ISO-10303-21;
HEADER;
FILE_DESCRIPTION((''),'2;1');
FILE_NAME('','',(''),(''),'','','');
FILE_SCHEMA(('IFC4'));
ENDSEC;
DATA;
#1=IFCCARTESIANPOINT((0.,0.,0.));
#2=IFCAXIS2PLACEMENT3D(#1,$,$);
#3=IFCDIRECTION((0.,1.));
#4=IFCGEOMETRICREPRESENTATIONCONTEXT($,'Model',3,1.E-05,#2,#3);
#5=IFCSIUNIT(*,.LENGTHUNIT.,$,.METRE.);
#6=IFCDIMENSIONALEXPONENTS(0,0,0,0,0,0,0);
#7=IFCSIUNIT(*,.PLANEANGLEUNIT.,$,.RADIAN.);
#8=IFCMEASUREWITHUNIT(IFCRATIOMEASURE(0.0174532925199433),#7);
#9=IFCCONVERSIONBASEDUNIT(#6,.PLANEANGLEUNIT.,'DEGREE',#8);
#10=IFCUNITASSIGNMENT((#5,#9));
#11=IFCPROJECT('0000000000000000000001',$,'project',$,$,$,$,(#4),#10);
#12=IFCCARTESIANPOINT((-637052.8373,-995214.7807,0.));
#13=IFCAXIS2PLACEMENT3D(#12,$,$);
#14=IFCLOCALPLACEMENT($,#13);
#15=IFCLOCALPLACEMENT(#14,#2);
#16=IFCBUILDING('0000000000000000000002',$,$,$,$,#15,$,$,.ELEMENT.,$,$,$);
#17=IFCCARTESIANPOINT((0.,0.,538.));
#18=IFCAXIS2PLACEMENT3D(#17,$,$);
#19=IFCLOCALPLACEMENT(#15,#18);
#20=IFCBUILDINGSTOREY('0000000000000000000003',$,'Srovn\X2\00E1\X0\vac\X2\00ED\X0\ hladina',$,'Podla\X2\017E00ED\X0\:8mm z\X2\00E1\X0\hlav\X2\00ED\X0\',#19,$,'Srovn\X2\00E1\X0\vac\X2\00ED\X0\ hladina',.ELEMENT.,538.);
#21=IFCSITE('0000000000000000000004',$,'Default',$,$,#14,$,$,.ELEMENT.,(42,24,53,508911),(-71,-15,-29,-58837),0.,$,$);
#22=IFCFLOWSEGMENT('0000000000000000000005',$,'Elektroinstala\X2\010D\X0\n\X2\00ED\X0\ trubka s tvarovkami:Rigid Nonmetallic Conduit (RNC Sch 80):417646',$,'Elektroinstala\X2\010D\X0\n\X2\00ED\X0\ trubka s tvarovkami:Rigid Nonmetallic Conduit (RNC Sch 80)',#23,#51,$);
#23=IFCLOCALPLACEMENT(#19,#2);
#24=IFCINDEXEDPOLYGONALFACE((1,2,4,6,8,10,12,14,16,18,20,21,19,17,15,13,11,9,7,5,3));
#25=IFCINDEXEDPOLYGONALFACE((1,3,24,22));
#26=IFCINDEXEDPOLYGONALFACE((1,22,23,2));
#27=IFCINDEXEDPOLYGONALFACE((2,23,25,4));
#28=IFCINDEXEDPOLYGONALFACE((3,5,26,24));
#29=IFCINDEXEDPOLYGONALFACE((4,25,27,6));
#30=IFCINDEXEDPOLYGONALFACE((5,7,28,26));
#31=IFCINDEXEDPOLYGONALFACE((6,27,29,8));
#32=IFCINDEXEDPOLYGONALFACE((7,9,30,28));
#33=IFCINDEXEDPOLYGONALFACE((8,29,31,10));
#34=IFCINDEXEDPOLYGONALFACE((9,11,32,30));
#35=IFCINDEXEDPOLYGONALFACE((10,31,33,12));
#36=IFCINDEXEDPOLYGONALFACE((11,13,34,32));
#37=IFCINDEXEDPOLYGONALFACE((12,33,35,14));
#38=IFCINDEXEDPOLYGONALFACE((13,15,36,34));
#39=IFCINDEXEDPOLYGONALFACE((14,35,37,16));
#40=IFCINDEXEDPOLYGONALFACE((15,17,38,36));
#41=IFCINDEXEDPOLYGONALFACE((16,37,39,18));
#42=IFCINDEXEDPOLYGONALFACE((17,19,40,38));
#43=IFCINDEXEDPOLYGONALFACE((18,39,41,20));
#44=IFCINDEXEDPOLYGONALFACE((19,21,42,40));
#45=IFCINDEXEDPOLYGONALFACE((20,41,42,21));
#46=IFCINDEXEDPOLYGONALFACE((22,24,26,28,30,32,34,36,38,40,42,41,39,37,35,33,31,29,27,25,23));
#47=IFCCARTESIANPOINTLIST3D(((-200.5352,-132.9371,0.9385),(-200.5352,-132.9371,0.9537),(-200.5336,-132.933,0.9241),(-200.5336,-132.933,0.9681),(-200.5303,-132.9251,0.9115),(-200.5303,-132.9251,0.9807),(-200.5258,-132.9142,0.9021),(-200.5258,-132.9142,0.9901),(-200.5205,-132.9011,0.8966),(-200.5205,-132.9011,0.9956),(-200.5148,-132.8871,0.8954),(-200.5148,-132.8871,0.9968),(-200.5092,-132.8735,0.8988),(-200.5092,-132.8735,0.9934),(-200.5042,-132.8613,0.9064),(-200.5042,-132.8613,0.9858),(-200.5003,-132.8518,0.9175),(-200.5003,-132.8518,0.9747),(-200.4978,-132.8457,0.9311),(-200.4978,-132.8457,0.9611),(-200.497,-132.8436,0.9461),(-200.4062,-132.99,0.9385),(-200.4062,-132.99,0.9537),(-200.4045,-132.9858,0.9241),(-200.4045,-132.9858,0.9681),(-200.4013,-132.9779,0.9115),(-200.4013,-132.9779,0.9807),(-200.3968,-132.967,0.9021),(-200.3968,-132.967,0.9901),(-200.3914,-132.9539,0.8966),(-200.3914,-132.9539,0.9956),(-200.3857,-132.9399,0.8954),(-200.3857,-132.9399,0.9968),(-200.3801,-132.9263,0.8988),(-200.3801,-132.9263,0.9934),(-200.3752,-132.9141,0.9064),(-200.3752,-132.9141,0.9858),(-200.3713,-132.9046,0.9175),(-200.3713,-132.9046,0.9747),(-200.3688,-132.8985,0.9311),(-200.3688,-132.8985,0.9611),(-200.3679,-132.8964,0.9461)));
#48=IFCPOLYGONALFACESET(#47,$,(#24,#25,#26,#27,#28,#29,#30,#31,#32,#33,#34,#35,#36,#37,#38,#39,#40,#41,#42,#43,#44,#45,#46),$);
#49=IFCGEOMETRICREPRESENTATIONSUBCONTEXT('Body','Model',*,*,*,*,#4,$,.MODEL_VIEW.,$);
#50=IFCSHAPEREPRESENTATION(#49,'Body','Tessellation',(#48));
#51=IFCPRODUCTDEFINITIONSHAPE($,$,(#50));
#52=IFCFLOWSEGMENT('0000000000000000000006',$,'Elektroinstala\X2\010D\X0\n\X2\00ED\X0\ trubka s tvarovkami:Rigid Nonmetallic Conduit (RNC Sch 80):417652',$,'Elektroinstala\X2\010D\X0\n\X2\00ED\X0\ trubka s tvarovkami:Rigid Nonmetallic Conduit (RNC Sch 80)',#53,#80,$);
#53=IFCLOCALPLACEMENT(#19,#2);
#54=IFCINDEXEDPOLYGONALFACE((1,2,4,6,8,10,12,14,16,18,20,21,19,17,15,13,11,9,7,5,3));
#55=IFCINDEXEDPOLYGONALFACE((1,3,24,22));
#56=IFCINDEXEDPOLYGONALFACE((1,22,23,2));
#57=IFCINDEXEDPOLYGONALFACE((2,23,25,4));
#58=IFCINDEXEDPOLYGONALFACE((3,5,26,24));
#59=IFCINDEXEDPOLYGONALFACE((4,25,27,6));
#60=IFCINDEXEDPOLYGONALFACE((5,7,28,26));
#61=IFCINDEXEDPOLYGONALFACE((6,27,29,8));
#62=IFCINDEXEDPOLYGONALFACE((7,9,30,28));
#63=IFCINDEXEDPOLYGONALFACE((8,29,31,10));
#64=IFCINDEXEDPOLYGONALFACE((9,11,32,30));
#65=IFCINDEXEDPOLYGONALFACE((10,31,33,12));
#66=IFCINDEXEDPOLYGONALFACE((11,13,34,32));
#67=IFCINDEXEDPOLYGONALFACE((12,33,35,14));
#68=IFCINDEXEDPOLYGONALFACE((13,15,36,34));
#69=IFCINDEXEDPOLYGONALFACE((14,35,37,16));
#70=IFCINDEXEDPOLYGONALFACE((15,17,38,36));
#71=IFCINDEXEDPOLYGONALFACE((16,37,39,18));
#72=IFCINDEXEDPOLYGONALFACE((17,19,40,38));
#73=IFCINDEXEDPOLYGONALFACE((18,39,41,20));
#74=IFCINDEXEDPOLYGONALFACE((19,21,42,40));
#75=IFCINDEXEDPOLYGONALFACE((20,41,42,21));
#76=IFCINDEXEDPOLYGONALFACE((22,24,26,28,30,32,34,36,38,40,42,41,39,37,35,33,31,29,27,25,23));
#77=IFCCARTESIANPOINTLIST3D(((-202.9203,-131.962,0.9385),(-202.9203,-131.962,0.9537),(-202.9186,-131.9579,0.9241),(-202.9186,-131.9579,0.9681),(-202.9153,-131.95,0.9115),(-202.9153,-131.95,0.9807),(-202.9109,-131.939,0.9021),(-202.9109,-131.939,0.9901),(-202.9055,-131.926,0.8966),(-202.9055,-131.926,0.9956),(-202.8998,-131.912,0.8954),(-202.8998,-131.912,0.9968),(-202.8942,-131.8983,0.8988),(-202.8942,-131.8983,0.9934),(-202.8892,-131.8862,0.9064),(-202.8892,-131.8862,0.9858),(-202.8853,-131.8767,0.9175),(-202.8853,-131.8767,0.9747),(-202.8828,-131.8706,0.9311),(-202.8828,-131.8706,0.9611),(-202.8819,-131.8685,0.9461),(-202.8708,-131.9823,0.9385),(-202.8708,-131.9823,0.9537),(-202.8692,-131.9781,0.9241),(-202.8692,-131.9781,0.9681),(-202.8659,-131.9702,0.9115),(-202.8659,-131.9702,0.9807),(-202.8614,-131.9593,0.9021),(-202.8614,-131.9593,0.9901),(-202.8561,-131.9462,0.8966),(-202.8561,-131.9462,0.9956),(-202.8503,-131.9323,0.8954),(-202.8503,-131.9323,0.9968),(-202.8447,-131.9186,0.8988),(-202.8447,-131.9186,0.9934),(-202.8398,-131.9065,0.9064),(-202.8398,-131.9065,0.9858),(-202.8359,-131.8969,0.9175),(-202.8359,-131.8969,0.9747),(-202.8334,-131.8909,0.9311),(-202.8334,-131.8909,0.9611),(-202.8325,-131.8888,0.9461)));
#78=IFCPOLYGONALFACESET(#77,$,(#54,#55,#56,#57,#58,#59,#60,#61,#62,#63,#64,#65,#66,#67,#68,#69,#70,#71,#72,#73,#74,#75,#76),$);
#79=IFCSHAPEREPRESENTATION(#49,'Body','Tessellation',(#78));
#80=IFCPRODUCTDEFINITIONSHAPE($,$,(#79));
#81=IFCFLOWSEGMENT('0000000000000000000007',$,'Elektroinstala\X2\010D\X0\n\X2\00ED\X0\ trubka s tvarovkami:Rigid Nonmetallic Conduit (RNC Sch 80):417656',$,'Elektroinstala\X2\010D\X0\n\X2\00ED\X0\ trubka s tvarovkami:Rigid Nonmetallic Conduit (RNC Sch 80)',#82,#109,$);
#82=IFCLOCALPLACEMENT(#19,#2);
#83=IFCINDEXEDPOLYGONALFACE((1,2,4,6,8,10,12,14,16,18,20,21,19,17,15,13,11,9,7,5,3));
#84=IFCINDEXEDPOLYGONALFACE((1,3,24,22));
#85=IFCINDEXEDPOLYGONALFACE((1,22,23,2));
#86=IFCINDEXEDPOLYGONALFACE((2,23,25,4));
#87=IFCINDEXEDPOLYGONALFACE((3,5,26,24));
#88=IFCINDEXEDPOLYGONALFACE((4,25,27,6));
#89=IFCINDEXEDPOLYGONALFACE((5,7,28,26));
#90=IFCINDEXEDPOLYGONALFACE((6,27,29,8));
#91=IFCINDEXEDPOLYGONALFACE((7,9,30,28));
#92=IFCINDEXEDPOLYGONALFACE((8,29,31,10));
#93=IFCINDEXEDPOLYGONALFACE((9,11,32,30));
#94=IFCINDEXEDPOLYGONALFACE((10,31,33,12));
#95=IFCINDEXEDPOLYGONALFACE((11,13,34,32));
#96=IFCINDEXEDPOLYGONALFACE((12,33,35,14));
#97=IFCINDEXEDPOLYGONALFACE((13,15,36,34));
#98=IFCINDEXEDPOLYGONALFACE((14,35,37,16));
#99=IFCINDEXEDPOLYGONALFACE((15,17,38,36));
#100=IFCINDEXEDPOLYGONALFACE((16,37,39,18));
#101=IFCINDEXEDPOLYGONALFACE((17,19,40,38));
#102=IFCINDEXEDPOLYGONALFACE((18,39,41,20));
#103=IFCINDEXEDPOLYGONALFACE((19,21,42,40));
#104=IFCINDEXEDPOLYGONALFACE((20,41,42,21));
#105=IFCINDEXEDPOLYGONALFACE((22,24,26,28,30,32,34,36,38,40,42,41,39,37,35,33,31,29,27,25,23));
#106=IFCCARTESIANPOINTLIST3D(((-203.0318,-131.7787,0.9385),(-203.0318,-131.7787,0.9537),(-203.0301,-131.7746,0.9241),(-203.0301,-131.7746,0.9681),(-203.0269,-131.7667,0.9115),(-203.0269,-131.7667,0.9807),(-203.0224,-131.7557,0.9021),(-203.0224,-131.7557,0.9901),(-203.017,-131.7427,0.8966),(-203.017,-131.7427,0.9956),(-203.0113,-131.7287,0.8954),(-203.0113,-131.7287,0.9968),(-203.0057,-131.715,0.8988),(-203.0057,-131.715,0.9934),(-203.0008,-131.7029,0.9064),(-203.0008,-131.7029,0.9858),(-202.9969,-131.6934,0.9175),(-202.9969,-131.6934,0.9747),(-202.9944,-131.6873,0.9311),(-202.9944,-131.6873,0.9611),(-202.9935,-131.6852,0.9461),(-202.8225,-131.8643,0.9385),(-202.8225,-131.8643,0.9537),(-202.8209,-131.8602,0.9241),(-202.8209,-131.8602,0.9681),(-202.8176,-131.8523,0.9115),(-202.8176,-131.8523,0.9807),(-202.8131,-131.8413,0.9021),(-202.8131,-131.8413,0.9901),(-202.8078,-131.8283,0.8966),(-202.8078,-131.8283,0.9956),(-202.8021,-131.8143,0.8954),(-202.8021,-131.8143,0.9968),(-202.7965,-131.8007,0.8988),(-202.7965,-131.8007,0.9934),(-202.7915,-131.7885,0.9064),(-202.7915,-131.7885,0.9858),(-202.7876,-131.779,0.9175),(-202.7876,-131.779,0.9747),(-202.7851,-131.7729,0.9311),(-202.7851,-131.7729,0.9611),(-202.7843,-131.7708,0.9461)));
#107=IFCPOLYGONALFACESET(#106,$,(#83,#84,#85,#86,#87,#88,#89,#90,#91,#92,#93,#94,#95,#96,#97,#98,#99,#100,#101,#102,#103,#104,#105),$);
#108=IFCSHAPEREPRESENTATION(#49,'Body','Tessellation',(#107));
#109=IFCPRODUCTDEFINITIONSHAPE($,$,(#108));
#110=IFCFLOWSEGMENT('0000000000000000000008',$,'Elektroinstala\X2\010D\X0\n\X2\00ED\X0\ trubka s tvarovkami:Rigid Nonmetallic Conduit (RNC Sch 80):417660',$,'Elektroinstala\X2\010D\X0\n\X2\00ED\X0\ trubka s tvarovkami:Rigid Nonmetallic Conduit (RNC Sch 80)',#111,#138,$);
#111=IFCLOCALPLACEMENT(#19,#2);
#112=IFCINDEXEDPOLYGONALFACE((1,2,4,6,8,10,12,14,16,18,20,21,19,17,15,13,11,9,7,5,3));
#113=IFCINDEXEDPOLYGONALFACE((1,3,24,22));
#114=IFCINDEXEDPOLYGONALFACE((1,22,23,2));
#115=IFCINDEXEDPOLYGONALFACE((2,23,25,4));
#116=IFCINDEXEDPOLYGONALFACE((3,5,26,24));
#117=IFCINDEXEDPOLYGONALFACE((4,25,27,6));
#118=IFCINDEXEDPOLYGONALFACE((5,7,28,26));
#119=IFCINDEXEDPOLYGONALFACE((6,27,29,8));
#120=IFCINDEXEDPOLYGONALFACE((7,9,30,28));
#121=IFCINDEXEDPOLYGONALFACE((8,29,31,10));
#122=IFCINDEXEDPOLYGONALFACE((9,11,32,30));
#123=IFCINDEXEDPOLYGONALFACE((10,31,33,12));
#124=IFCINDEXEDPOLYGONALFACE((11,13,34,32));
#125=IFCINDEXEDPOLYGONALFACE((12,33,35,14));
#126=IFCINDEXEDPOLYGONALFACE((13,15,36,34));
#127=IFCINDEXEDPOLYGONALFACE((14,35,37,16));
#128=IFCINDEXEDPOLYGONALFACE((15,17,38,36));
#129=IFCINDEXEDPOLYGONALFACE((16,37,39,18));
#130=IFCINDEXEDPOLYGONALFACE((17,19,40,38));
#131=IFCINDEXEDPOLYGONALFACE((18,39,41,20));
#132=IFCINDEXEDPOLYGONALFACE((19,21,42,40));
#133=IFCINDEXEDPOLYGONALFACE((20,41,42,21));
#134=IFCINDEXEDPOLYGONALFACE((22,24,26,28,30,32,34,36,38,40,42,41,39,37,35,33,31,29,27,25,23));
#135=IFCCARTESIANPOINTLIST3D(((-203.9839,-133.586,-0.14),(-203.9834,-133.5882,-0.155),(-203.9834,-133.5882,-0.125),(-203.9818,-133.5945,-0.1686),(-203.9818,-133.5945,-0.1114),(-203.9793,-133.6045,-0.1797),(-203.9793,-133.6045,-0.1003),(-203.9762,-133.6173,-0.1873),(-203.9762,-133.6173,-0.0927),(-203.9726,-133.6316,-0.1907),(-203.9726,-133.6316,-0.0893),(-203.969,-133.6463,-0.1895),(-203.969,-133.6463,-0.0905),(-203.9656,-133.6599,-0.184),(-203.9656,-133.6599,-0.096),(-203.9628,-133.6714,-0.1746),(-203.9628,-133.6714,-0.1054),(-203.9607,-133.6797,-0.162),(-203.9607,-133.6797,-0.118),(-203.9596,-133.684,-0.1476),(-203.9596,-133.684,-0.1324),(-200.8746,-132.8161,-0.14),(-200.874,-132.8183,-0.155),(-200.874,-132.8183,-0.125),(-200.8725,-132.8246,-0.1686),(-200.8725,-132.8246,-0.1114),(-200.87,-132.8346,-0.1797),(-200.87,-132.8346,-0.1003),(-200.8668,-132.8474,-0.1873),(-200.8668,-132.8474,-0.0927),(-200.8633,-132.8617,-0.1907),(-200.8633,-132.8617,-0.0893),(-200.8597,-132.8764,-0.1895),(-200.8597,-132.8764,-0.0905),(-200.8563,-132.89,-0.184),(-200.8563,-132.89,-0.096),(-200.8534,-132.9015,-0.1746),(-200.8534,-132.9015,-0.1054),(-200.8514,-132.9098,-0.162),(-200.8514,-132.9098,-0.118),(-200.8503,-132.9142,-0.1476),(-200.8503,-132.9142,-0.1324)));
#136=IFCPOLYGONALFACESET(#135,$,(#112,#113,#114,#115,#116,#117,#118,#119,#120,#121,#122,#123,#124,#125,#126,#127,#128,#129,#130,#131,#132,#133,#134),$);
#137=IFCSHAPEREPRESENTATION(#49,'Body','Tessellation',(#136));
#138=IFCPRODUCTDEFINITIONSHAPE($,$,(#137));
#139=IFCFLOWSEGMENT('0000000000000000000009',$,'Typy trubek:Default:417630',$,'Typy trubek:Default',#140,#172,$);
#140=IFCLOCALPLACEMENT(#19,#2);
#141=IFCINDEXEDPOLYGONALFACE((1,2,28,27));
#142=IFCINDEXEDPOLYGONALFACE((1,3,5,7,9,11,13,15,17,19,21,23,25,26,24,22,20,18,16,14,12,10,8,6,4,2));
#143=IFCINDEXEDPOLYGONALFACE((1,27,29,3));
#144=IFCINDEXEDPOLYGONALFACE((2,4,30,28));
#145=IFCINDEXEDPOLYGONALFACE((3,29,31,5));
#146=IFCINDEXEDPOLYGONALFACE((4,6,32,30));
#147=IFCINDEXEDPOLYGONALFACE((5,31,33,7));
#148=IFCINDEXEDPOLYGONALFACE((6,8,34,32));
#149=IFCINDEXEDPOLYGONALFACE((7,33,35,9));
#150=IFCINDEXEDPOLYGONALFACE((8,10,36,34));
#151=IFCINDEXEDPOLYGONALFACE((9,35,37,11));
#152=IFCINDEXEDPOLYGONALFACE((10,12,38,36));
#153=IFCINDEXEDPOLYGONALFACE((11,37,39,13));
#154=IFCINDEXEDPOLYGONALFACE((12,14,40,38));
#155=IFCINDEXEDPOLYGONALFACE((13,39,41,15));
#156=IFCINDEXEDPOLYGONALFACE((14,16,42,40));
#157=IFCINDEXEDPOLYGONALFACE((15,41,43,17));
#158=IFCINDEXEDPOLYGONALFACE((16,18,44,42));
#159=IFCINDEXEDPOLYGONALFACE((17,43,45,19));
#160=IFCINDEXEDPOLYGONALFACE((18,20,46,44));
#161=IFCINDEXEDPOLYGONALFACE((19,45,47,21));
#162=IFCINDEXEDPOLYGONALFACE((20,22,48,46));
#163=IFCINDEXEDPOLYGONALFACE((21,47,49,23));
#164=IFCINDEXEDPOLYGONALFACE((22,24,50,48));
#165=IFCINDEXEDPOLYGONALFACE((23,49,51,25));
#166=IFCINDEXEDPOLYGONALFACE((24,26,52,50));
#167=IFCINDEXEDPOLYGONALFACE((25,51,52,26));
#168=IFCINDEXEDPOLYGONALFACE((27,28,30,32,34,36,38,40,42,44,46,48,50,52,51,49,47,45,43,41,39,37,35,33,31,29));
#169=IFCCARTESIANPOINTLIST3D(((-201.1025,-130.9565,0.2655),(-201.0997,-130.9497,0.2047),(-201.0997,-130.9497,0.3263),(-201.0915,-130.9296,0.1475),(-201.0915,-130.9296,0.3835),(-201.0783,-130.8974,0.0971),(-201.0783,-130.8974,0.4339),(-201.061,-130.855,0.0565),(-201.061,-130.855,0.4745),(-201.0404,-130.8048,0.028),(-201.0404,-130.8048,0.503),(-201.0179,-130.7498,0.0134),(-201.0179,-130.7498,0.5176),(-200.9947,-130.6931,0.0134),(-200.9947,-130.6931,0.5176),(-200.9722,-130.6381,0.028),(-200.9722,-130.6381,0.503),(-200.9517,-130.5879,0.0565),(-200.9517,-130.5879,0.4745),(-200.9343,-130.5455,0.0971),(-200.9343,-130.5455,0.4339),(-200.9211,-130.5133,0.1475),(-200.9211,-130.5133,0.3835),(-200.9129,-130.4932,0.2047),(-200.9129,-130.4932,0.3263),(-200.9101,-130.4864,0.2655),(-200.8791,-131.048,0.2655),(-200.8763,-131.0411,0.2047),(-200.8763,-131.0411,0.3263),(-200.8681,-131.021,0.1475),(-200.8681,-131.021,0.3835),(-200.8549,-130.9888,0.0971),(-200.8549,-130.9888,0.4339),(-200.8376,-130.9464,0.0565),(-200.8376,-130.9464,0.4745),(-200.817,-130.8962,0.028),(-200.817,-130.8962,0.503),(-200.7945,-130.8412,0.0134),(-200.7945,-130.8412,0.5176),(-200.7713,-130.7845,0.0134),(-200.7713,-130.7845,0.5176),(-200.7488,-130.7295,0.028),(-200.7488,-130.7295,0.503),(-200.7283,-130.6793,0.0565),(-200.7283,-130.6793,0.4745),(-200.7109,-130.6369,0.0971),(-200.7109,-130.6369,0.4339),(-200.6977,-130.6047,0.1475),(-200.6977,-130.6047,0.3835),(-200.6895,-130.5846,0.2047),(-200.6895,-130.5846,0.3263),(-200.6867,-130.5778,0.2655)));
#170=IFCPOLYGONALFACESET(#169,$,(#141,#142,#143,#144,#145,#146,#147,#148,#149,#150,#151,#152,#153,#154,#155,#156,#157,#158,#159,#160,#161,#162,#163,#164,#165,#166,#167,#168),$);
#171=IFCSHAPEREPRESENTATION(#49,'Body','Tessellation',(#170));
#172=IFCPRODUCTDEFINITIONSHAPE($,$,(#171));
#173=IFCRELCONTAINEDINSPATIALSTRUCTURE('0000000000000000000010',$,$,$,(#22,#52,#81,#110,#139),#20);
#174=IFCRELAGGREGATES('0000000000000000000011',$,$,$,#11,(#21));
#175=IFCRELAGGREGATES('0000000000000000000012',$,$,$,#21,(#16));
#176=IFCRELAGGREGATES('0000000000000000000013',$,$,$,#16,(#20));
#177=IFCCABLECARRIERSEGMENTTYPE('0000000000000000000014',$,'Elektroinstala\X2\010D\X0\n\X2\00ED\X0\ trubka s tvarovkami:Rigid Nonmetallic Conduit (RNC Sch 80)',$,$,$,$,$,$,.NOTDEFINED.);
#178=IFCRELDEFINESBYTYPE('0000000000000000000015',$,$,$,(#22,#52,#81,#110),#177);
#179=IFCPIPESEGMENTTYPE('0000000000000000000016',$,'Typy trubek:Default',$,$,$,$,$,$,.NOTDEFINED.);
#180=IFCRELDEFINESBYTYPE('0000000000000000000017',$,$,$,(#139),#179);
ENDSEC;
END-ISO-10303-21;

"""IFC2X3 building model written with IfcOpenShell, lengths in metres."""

from ifc_helpers import new_model, entity, si_unit, converted_unit, direction, frame, frame_2d, origin, origin_2d_with_axis, place, context, subcontext, project, spatial, circle, extrude, type_object, element, save


model = new_model("IFC2X3")

# Units and contexts
model_context = context("Model", 3, precision=1e-05, world=origin(), true_north=direction((0.0, 1.0)))
body_context = subcontext(model_context, "Body", "Model", "MODEL_VIEW")
ifc_project = project(units=[si_unit("LENGTHUNIT", "METRE"), converted_unit("PLANEANGLEUNIT", "DEGREE", entity("IfcRatioMeasure", 0.0174532925199433), si_unit("PLANEANGLEUNIT", "RADIAN"), dimensions=[0, 0, 0, 0, 0, 0, 0])], contexts=[model_context])

# Site, building, storey
site_placement = place(None, frame((-637052.8373, -995214.7807, 0.0)))
site = spatial("IfcSite", under=ifc_project, at=site_placement, Name="Default", CompositionType="ELEMENT", RefLatitude=(42, 24, 53, 508911), RefLongitude=(-71, -15, -29, -58837), RefElevation=0.0)
building_placement = place(site_placement, origin())
building = spatial("IfcBuilding", under=site, at=building_placement, CompositionType="ELEMENT")
storey_placement = place(building_placement, frame((0.0, 0.0, 538.0)))
storey = spatial("IfcBuildingStorey", under=building, at=storey_placement, Name="Srovnávací hladina", ObjectType="Podlaží:8mm záhlaví", LongName="Srovnávací hladina", CompositionType="ELEMENT", Elevation=538.0)

# Flow segments
cable_carrier_segment_type = type_object("IfcCableCarrierSegmentType", Name="Elektroinstalační trubka s tvarovkami:Rigid Nonmetallic Conduit (RNC Sch 80)", PredefinedType="NOTDEFINED")
flow_segment_1_placement = place(storey_placement, origin())
element("IfcFlowSegment", 1, at=flow_segment_1_placement, inside=storey, type_object=cable_carrier_segment_type, Name="Elektroinstalační trubka s tvarovkami:Rigid Nonmetallic Conduit (RNC Sch 80):417646", ObjectType="Elektroinstalační trubka s tvarovkami:Rigid Nonmetallic Conduit (RNC Sch 80)", context=body_context, shape_type="SweptSolid", body=[
    extrude(circle(Radius=0.0508, at=origin_2d_with_axis()), frame((-200.3872, -132.9435, 0.9461), z_axis=(-0.92551, 0.378722, 0.0), x_axis=(0.378722, 0.92551, 0.0)), (0.0, 0.0, 1.0), 0.1394),
])
flow_segment_2_placement = place(storey_placement, origin())
element("IfcFlowSegment", 2, at=flow_segment_2_placement, inside=storey, type_object=cable_carrier_segment_type, Name="Elektroinstalační trubka s tvarovkami:Rigid Nonmetallic Conduit (RNC Sch 80):417652", ObjectType="Elektroinstalační trubka s tvarovkami:Rigid Nonmetallic Conduit (RNC Sch 80)", context=body_context, shape_type="SweptSolid", body=[
    extrude(circle(Radius=0.0508, at=origin_2d_with_axis()), frame((-202.9012, -131.9155, 0.9461), z_axis=(0.925194, -0.379493, 0.0), x_axis=(0.379493, 0.925194, 0.0)), (0.0, 0.0, 1.0), 0.0534),
])
flow_segment_3_placement = place(storey_placement, origin())
element("IfcFlowSegment", 3, at=flow_segment_3_placement, inside=storey, type_object=cable_carrier_segment_type, Name="Elektroinstalační trubka s tvarovkami:Rigid Nonmetallic Conduit (RNC Sch 80):417656", ObjectType="Elektroinstalační trubka s tvarovkami:Rigid Nonmetallic Conduit (RNC Sch 80)", context=body_context, shape_type="SweptSolid", body=[
    extrude(circle(Radius=0.0508, at=origin_2d_with_axis()), frame((-202.8035, -131.8178, 0.9461), z_axis=(-0.92551, 0.378722, 0.0), x_axis=(0.378722, 0.92551, 0.0)), (0.0, 0.0, 1.0), 0.2261),
])
flow_segment_4_placement = place(storey_placement, origin())
element("IfcFlowSegment", 4, at=flow_segment_4_placement, inside=storey, type_object=cable_carrier_segment_type, Name="Elektroinstalační trubka s tvarovkami:Rigid Nonmetallic Conduit (RNC Sch 80):417660", ObjectType="Elektroinstalační trubka s tvarovkami:Rigid Nonmetallic Conduit (RNC Sch 80)", context=body_context, shape_type="SweptSolid", body=[
    extrude(circle(Radius=0.0508, at=frame_2d((0.0, 0.0), x_axis=(1.0, 0.0))), frame((-203.9717, -133.6353, -0.14), z_axis=(0.970687, 0.240348, 0.0), x_axis=(-0.240348, 0.970687, 0.0)), (0.0, 0.0, 1.0), 3.2032),
])
pipe_segment_type = type_object("IfcPipeSegmentType", Name="Typy trubek:Default", PredefinedType="NOTDEFINED")
flow_segment_5_placement = place(storey_placement, origin())
element("IfcFlowSegment", 5, at=flow_segment_5_placement, inside=storey, type_object=pipe_segment_type, Name="Typy trubek:Default:417630", ObjectType="Typy trubek:Default", context=body_context, shape_type="SweptSolid", body=[
    extrude(circle(Radius=0.254, at=origin_2d_with_axis()), frame((-200.7829, -130.8129, 0.2655), z_axis=(-0.92551, 0.378722, 0.0), x_axis=(-0.378722, -0.92551, 0.0)), (0.0, 0.0, 1.0), 0.2414),
])

save(model, "model.ifc")
